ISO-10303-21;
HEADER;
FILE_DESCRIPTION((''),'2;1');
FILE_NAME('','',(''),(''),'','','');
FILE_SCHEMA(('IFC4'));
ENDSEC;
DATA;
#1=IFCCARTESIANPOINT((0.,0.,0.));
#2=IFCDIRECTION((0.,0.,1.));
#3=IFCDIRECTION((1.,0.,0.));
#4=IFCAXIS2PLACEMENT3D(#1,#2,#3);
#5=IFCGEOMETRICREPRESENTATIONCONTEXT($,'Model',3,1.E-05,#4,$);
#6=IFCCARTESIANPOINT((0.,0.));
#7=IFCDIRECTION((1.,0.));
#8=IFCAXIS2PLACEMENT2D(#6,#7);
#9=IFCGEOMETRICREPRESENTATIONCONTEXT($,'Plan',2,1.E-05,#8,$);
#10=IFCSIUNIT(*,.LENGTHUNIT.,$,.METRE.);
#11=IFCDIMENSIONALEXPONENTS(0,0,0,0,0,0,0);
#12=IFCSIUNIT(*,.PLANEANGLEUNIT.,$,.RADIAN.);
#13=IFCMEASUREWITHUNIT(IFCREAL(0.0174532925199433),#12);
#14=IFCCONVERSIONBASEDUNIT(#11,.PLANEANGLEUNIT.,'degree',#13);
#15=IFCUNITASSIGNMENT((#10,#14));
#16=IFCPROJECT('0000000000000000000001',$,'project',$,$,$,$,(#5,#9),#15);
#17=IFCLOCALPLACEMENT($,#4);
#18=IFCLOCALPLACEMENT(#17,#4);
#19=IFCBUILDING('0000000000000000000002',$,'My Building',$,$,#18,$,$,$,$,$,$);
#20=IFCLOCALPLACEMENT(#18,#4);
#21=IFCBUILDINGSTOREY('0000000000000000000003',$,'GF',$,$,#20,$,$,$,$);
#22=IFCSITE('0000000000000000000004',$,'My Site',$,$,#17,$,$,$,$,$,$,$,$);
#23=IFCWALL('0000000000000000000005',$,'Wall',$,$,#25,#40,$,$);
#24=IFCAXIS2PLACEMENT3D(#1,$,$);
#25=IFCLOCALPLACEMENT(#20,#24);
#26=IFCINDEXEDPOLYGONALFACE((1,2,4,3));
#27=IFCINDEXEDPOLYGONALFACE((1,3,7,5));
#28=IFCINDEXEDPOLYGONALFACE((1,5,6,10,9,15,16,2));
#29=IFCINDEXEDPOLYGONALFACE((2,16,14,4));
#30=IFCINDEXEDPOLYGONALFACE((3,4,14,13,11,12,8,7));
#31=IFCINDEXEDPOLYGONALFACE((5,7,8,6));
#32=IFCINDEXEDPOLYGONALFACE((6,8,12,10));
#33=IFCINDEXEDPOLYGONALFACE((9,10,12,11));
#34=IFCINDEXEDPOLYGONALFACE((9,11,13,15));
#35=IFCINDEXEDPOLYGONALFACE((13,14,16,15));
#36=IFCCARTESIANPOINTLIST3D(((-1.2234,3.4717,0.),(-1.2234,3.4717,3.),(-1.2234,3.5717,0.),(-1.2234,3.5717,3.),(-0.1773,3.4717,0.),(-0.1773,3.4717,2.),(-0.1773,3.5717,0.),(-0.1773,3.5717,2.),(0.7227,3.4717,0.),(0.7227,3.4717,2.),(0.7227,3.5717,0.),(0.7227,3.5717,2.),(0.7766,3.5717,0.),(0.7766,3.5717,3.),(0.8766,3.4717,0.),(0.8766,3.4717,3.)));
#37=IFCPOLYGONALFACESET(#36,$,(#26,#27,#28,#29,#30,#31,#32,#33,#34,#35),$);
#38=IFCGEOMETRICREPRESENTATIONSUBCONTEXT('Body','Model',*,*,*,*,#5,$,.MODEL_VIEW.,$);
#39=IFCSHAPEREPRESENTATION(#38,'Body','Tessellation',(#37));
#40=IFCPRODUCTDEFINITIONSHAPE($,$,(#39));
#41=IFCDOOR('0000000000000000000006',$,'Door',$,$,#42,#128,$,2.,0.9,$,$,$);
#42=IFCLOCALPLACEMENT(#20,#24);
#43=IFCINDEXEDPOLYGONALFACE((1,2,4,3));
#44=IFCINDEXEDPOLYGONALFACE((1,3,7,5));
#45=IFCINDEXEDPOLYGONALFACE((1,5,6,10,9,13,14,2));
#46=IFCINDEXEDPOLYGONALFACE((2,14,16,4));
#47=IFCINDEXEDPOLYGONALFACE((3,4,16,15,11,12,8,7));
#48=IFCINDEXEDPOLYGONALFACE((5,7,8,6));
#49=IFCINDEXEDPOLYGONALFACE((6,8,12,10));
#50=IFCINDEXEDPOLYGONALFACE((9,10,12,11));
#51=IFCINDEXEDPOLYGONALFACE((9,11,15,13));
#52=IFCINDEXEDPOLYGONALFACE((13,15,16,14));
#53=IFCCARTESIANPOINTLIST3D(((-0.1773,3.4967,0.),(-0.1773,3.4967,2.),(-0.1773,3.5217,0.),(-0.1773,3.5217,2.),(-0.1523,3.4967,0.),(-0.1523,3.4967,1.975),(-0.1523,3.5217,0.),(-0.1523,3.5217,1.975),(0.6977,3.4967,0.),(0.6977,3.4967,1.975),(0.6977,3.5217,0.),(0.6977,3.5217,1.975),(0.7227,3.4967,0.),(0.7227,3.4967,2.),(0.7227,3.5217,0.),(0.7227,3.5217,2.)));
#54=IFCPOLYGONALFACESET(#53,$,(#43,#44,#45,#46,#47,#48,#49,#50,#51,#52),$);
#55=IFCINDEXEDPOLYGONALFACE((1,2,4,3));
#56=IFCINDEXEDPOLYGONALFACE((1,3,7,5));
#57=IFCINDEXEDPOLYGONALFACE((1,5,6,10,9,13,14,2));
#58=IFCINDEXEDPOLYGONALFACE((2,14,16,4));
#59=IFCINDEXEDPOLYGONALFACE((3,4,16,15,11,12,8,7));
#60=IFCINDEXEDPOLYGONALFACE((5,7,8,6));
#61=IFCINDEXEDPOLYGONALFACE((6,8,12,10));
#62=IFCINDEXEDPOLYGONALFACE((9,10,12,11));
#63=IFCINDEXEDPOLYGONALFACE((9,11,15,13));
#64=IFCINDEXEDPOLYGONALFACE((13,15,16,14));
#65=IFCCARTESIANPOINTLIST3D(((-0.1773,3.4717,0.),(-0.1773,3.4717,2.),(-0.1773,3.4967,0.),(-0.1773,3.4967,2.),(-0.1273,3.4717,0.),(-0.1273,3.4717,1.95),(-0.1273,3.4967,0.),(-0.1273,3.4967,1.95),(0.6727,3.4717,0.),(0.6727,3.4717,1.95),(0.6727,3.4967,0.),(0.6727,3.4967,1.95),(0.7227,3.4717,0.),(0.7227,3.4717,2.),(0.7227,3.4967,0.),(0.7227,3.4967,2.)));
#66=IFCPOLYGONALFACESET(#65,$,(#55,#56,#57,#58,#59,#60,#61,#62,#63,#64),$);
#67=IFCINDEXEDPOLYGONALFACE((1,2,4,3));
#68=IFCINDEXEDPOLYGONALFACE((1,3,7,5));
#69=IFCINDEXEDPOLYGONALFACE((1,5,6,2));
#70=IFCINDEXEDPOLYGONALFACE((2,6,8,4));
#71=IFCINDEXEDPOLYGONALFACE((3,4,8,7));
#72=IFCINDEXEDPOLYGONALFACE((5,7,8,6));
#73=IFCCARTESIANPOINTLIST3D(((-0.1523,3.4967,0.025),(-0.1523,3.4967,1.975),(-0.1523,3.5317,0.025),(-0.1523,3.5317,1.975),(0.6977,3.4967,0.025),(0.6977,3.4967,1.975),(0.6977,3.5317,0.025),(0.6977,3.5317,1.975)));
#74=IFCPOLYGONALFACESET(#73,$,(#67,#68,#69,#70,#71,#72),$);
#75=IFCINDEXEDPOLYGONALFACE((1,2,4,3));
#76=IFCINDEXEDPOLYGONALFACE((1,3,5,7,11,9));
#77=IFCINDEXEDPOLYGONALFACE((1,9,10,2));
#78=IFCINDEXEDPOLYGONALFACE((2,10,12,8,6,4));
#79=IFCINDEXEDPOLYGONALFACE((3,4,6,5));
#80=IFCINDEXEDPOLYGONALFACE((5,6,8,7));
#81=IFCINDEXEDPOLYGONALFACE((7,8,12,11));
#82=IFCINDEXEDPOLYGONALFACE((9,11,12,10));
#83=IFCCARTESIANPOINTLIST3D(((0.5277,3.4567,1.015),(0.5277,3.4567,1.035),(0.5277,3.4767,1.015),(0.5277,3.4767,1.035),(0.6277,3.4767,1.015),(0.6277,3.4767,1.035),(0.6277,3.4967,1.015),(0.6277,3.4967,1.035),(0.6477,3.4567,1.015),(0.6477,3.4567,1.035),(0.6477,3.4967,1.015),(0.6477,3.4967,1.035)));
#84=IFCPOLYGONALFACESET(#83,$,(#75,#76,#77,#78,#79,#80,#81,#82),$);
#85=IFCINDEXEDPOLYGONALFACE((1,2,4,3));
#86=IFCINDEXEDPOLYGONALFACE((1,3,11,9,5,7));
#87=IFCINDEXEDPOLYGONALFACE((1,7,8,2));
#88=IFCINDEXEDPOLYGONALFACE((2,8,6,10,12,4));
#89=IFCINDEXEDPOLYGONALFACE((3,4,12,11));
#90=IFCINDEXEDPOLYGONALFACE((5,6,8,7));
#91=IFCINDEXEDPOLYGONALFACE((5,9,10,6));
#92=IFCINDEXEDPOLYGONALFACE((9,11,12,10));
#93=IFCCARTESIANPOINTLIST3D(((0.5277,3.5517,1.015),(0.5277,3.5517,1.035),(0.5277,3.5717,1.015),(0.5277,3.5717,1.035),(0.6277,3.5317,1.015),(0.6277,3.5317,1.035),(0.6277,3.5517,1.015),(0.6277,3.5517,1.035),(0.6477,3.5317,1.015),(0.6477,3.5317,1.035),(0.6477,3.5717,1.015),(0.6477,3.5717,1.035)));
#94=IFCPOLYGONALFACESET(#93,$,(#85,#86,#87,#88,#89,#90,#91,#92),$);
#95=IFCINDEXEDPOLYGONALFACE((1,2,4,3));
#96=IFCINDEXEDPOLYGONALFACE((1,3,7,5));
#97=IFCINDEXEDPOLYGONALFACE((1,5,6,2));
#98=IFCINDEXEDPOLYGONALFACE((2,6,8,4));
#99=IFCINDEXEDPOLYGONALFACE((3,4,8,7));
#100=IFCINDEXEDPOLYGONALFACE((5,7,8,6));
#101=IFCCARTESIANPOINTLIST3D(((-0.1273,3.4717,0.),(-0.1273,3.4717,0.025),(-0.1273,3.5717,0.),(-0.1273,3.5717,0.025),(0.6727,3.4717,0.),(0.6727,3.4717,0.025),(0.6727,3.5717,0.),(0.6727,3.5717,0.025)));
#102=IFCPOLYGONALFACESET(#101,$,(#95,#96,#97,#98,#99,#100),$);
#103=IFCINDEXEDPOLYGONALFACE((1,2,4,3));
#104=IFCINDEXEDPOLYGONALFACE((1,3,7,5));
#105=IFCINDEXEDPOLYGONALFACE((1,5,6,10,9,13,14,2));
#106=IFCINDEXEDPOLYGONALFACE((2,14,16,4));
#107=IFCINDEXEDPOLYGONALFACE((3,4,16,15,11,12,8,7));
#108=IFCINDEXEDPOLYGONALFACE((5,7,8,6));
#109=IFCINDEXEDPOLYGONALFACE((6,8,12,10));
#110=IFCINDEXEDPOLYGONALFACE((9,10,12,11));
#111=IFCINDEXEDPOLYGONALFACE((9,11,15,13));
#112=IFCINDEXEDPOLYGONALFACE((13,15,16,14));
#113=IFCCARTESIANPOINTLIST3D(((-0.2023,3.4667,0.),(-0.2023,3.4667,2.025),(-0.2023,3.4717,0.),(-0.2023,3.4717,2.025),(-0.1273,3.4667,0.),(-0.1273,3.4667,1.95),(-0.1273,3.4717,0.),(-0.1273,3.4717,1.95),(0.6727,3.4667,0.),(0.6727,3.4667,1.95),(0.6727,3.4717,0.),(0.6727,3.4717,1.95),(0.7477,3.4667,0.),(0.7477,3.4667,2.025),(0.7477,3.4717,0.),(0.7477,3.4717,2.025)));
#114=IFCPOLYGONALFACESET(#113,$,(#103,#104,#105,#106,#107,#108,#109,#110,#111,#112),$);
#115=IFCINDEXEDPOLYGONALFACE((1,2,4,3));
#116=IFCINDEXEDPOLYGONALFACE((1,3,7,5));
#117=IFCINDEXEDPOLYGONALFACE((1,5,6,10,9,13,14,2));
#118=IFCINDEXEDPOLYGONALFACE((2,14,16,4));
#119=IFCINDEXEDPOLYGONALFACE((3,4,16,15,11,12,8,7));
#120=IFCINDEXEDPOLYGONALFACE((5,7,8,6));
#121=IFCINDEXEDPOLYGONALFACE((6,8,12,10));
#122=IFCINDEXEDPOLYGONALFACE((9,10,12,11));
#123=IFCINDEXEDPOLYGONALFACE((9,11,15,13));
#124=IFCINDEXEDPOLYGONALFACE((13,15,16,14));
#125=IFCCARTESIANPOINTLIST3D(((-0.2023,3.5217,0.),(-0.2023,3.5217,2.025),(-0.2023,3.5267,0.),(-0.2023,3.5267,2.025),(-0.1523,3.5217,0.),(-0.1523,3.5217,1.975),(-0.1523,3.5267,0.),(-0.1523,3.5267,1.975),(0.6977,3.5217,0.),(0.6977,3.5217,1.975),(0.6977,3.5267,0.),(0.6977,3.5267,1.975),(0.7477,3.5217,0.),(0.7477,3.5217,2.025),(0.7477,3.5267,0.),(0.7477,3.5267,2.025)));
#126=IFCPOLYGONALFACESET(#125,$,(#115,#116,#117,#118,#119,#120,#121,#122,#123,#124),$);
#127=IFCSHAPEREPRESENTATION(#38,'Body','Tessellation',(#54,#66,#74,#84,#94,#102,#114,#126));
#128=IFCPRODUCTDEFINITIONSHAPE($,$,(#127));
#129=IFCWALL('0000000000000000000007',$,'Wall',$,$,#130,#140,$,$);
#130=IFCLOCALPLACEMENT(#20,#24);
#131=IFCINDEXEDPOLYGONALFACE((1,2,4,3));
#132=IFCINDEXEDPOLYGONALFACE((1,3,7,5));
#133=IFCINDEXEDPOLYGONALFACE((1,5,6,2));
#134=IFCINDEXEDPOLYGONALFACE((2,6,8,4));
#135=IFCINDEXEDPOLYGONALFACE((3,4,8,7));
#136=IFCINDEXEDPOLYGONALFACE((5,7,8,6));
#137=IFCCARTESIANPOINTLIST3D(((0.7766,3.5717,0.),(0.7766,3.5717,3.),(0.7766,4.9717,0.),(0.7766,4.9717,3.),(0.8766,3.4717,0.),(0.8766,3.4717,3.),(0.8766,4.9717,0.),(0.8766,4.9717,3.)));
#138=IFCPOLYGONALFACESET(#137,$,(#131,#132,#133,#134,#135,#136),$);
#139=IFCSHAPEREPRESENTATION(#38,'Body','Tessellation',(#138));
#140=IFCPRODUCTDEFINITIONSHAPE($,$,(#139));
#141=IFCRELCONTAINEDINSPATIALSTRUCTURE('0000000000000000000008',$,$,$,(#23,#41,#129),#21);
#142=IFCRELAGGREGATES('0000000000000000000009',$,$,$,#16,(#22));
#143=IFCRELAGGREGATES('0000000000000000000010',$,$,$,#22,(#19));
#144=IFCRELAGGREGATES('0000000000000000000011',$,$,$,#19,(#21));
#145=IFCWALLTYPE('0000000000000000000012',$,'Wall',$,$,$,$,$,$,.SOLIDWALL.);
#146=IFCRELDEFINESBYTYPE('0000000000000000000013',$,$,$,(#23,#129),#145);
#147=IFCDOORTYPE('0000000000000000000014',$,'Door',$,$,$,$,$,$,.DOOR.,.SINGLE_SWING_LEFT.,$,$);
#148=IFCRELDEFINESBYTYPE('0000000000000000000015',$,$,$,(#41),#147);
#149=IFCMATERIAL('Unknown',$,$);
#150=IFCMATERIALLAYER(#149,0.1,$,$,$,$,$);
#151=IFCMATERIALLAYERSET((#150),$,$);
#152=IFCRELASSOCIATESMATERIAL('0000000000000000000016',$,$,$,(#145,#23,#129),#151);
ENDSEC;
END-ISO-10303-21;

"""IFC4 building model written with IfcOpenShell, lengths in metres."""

from ifc_helpers import new_model, entity, si_unit, converted_unit, frame, origin_with_axes, origin_2d_with_axis, place, context, subcontext, project, spatial, line, indexed_curve, outline, extrude, shape, source, transform, mapped, material, layer, layer_set, layer_usage, type_object, type_shapes, element, fill, save


model = new_model("IFC4")

# Units and contexts
model_context = context("Model", 3, precision=1e-05, world=origin_with_axes())
plan_context = context("Plan", 2, precision=1e-05, world=origin_2d_with_axis())
body_context_1 = subcontext(model_context, "Body", "Model", "MODEL_VIEW")
body_context_2 = subcontext(plan_context, "Body", "Plan", "PLAN_VIEW")
ifc_project = project(units=[si_unit("LENGTHUNIT", "METRE"), converted_unit("PLANEANGLEUNIT", "degree", entity("IfcReal", 0.0174532925199433), si_unit("PLANEANGLEUNIT", "RADIAN"), dimensions=[0, 0, 0, 0, 0, 0, 0])], contexts=[model_context, plan_context])

# Site, building, storey
site_placement = place(None, origin_with_axes())
site = spatial("IfcSite", under=ifc_project, at=site_placement, Name="My Site")
building_placement = place(site_placement, origin_with_axes())
building = spatial("IfcBuilding", under=site, at=building_placement, Name="My Building")
storey_placement = place(building_placement, origin_with_axes())
storey = spatial("IfcBuildingStorey", under=building, at=storey_placement, Name="GF")

# Shared definitions
ifc_material = material(Name="Unknown")

# Shared definitions
ifc_layer = layer(ifc_material, 0.1)
ifc_layer_set = layer_set([ifc_layer])
wall_type = type_object("IfcWallType", Name="Wall", PredefinedType="SOLIDWALL", material=ifc_layer_set)

# Shared definitions
shared_shape_1 = source(origin_with_axes(), body_context_1, "Body", "SweptSolid", [
    extrude(outline(indexed_curve([(0.0, 0.0), (0.9, 0.0), (0.9, 2.0), (0.0, 2.0)], segments=[line(1, 2, 3, 4, 1)])), frame((0.0, -0.6, 0.0), z_axis=(0.0, -1.0, 0.0), x_axis=(1.0, 0.0, 0.0)), (0.0, 0.0, -1.0), 1.2),
])
door_type = type_object("IfcDoorType", Name="Door", OperationType="SINGLE_SWING_LEFT", PredefinedType="DOOR")
shared_shape_2 = source(origin_with_axes(), body_context_1, "Body", "SweptSolid", [
    extrude(outline(indexed_curve([(0.0, 0.0), (0.0, 2.0), (0.9, 2.0), (0.9, 0.0), (0.875, 0.0), (0.875, 1.975), (0.025, 1.975), (0.025, 0.0)], segments=[line(1, 2, 3, 4, 5, 6, 7, 8, 1)])), frame((0.0, 0.025, 0.0), z_axis=(0.0, -1.0, 0.0), x_axis=(1.0, 0.0, 0.0)), (0.0, 0.0, -1.0), 0.025),
    extrude(outline(indexed_curve([(0.0, 0.0), (0.0, 2.0), (0.9, 2.0), (0.9, 0.0), (0.85, 0.0), (0.85, 1.95), (0.05, 1.95), (0.05, 0.0)], segments=[line(1, 2, 3, 4, 5, 6, 7, 8, 1)])), frame((0.0, 0.0, 0.0), z_axis=(0.0, -1.0, 0.0), x_axis=(1.0, 0.0, 0.0)), (0.0, 0.0, -1.0), 0.025),
    extrude(outline(indexed_curve([(0.0, 0.0), (0.85, 0.0), (0.85, 0.035), (0.0, 0.035)], segments=[line(1, 2, 3, 4, 1)])), frame((0.025, 0.025, 0.025), z_axis=(0.0, 0.0, 1.0), x_axis=(1.0, 0.0, 0.0)), (0.0, 0.0, 1.0), 1.95),
    extrude(outline(indexed_curve([(0.0, 0.0), (0.0, -0.04), (-0.12, -0.04), (-0.12, -0.02), (-0.02, -0.02), (-0.02, 0.0)], segments=[line(1, 2, 3, 4, 5, 6, 1)])), frame((0.825, 0.025, 1.015), z_axis=(0.0, 0.0, 1.0), x_axis=(1.0, 0.0, 0.0)), (0.0, 0.0, 1.0), 0.02),
    extrude(outline(indexed_curve([(0.0, 0.0), (0.0, 0.04), (-0.12, 0.04), (-0.12, 0.02), (-0.02, 0.02), (-0.02, 0.0)], segments=[line(1, 2, 3, 4, 5, 6, 1)])), frame((0.825, 0.06, 1.015), z_axis=(0.0, 0.0, 1.0), x_axis=(1.0, 0.0, 0.0)), (0.0, 0.0, 1.0), 0.02),
    extrude(outline(indexed_curve([(0.0, 0.0), (0.8, 0.0), (0.8, 0.1), (0.0, 0.1)], segments=[line(1, 2, 3, 4, 1)])), frame((0.05, 0.0, 0.0), z_axis=(0.0, 0.0, 1.0), x_axis=(1.0, 0.0, 0.0)), (0.0, 0.0, 1.0), 0.025),
    extrude(outline(indexed_curve([(0.0, 0.0), (0.0, 2.025), (0.95, 2.025), (0.95, 0.0), (0.875, 0.0), (0.875, 1.95), (0.075, 1.95), (0.075, 0.0)], segments=[line(1, 2, 3, 4, 5, 6, 7, 8, 1)])), frame((-0.025, -0.005, 0.0), z_axis=(0.0, -1.0, 0.0), x_axis=(1.0, 0.0, 0.0)), (0.0, 0.0, -1.0), 0.005),
    extrude(outline(indexed_curve([(0.0, 0.0), (0.0, 2.025), (0.95, 2.025), (0.95, 0.0), (0.9, 0.0), (0.9, 1.975), (0.05, 1.975), (0.05, 0.0)], segments=[line(1, 2, 3, 4, 5, 6, 7, 8, 1)])), frame((-0.025, 0.05, 0.0), z_axis=(0.0, -1.0, 0.0), x_axis=(1.0, 0.0, 0.0)), (0.0, 0.0, -1.0), 0.005),
])
shared_shape_3 = source(origin_with_axes(), body_context_2, "Body", "Curve2D", [
    entity("IfcIndexedPolyCurve", entity("IfcCartesianPointList2D", [[0.0, 0.0], [0.0, 0.05], [0.025, 0.05], [0.025, 0.025], [0.05, 0.025], [0.05, 0.0]]), [entity("IfcLineIndex", [1, 2, 3, 4, 5, 6, 1])]),
    entity("IfcIndexedPolyCurve", entity("IfcCartesianPointList2D", [[0.9, 0.0], [0.9, 0.05], [0.875, 0.05], [0.875, 0.025], [0.85, 0.025], [0.85, 0.0]]), [entity("IfcLineIndex", [1, 2, 3, 4, 5, 6, 1])]),
    entity("IfcTrimmedCurve", entity("IfcEllipse", entity("IfcAxis2Placement2D", entity("IfcCartesianPoint", [0.06, 0.05]), entity("IfcDirection", [1.0, 0.0])), 0.815, 0.85), [entity("IfcCartesianPoint", [0.875, 0.05])], [entity("IfcCartesianPoint", [0.06, 0.9])], True, "CARTESIAN"),
    entity("IfcIndexedPolyCurve", entity("IfcCartesianPointList2D", [[0.025, 0.05], [0.06, 0.05], [0.06, 0.9], [0.025, 0.9]]), [entity("IfcLineIndex", [1, 2, 3, 4, 1])]),
])
type_shapes(door_type, [shared_shape_2, shared_shape_3])

# Wall, opening, door
ifc_layer_usage_1 = layer_usage(ifc_layer_set, "AXIS2", "POSITIVE", 0.0)
wall_1_placement = place(storey_placement, frame((-1.2234, 3.4717, 0.0), z_axis=(0.0, 0.0, 1.0), x_axis=(1.0, 0.0, 0.0)))
wall_1 = element("IfcWall", 1, at=wall_1_placement, inside=storey, type_object=wall_type, material=ifc_layer_usage_1, Name="Wall", context=body_context_1, shape_type="SweptSolid", body=[
    extrude(outline(indexed_curve([(0.0, 0.0), (0.0, 0.1), (2.0, 0.1), (2.1, 0.0)], segments=[line(1, 2, 3, 4, 1)])), origin_with_axes(), (0.0, 0.0, 1.0), 3.0),
])
opening_1_placement = place(wall_1_placement, frame((1.046, 0.0, 0.0), z_axis=(0.0, 0.0, 1.0), x_axis=(1.0, 0.0, 0.0)))
opening_1 = element("IfcOpeningElement", 2, at=opening_1_placement, cuts=wall_1, PredefinedType="OPENING", context=body_context_1, shape_type="MappedRepresentation", body=[
    mapped(shared_shape_1, transform((0.0, 0.0, 0.0), x_axis=(1.0, 0.0, 0.0), y_axis=(0.0, 1.0, 0.0), z_axis=(0.0, 0.0, 1.0), scale=1.0)),
])
door_1_placement = place(opening_1_placement, origin_with_axes())
door_1 = element("IfcDoor", 3, at=door_1_placement, inside=storey, type_object=door_type, Name="Door", OverallHeight=2.0, OverallWidth=0.9, shapes=[
    shape(body_context_1, "Body", "MappedRepresentation", [mapped(shared_shape_2, transform((0.0, 0.0, 0.0), x_axis=(1.0, 0.0, 0.0), y_axis=(0.0, 1.0, 0.0), z_axis=(0.0, 0.0, 1.0), scale=1.0))]),
    shape(body_context_2, "Body", "MappedRepresentation", [mapped(shared_shape_3, transform((0.0, 0.0, 0.0), x_axis=(1.0, 0.0, 0.0), y_axis=(0.0, 1.0, 0.0), z_axis=(0.0, 0.0, 1.0), scale=1.0))]),
])
fill(opening_1, door_1)

# Wall
ifc_layer_usage_2 = layer_usage(ifc_layer_set, "AXIS2", "POSITIVE", 0.0)
wall_2_placement = place(storey_placement, frame((0.8766, 3.4717, 0.0), z_axis=(0.0, 0.0, 1.0), x_axis=(0.0, 1.0, 0.0)))
element("IfcWall", 4, at=wall_2_placement, inside=storey, type_object=wall_type, material=ifc_layer_usage_2, Name="Wall", context=body_context_1, shape_type="SweptSolid", body=[
    extrude(outline(indexed_curve([(0.0, 0.0), (0.1, 0.1), (1.5, 0.1), (1.5, 0.0)], segments=[line(1, 2, 3, 4, 1)])), origin_with_axes(), (0.0, 0.0, 1.0), 3.0),
])

save(model, "model.ifc")
